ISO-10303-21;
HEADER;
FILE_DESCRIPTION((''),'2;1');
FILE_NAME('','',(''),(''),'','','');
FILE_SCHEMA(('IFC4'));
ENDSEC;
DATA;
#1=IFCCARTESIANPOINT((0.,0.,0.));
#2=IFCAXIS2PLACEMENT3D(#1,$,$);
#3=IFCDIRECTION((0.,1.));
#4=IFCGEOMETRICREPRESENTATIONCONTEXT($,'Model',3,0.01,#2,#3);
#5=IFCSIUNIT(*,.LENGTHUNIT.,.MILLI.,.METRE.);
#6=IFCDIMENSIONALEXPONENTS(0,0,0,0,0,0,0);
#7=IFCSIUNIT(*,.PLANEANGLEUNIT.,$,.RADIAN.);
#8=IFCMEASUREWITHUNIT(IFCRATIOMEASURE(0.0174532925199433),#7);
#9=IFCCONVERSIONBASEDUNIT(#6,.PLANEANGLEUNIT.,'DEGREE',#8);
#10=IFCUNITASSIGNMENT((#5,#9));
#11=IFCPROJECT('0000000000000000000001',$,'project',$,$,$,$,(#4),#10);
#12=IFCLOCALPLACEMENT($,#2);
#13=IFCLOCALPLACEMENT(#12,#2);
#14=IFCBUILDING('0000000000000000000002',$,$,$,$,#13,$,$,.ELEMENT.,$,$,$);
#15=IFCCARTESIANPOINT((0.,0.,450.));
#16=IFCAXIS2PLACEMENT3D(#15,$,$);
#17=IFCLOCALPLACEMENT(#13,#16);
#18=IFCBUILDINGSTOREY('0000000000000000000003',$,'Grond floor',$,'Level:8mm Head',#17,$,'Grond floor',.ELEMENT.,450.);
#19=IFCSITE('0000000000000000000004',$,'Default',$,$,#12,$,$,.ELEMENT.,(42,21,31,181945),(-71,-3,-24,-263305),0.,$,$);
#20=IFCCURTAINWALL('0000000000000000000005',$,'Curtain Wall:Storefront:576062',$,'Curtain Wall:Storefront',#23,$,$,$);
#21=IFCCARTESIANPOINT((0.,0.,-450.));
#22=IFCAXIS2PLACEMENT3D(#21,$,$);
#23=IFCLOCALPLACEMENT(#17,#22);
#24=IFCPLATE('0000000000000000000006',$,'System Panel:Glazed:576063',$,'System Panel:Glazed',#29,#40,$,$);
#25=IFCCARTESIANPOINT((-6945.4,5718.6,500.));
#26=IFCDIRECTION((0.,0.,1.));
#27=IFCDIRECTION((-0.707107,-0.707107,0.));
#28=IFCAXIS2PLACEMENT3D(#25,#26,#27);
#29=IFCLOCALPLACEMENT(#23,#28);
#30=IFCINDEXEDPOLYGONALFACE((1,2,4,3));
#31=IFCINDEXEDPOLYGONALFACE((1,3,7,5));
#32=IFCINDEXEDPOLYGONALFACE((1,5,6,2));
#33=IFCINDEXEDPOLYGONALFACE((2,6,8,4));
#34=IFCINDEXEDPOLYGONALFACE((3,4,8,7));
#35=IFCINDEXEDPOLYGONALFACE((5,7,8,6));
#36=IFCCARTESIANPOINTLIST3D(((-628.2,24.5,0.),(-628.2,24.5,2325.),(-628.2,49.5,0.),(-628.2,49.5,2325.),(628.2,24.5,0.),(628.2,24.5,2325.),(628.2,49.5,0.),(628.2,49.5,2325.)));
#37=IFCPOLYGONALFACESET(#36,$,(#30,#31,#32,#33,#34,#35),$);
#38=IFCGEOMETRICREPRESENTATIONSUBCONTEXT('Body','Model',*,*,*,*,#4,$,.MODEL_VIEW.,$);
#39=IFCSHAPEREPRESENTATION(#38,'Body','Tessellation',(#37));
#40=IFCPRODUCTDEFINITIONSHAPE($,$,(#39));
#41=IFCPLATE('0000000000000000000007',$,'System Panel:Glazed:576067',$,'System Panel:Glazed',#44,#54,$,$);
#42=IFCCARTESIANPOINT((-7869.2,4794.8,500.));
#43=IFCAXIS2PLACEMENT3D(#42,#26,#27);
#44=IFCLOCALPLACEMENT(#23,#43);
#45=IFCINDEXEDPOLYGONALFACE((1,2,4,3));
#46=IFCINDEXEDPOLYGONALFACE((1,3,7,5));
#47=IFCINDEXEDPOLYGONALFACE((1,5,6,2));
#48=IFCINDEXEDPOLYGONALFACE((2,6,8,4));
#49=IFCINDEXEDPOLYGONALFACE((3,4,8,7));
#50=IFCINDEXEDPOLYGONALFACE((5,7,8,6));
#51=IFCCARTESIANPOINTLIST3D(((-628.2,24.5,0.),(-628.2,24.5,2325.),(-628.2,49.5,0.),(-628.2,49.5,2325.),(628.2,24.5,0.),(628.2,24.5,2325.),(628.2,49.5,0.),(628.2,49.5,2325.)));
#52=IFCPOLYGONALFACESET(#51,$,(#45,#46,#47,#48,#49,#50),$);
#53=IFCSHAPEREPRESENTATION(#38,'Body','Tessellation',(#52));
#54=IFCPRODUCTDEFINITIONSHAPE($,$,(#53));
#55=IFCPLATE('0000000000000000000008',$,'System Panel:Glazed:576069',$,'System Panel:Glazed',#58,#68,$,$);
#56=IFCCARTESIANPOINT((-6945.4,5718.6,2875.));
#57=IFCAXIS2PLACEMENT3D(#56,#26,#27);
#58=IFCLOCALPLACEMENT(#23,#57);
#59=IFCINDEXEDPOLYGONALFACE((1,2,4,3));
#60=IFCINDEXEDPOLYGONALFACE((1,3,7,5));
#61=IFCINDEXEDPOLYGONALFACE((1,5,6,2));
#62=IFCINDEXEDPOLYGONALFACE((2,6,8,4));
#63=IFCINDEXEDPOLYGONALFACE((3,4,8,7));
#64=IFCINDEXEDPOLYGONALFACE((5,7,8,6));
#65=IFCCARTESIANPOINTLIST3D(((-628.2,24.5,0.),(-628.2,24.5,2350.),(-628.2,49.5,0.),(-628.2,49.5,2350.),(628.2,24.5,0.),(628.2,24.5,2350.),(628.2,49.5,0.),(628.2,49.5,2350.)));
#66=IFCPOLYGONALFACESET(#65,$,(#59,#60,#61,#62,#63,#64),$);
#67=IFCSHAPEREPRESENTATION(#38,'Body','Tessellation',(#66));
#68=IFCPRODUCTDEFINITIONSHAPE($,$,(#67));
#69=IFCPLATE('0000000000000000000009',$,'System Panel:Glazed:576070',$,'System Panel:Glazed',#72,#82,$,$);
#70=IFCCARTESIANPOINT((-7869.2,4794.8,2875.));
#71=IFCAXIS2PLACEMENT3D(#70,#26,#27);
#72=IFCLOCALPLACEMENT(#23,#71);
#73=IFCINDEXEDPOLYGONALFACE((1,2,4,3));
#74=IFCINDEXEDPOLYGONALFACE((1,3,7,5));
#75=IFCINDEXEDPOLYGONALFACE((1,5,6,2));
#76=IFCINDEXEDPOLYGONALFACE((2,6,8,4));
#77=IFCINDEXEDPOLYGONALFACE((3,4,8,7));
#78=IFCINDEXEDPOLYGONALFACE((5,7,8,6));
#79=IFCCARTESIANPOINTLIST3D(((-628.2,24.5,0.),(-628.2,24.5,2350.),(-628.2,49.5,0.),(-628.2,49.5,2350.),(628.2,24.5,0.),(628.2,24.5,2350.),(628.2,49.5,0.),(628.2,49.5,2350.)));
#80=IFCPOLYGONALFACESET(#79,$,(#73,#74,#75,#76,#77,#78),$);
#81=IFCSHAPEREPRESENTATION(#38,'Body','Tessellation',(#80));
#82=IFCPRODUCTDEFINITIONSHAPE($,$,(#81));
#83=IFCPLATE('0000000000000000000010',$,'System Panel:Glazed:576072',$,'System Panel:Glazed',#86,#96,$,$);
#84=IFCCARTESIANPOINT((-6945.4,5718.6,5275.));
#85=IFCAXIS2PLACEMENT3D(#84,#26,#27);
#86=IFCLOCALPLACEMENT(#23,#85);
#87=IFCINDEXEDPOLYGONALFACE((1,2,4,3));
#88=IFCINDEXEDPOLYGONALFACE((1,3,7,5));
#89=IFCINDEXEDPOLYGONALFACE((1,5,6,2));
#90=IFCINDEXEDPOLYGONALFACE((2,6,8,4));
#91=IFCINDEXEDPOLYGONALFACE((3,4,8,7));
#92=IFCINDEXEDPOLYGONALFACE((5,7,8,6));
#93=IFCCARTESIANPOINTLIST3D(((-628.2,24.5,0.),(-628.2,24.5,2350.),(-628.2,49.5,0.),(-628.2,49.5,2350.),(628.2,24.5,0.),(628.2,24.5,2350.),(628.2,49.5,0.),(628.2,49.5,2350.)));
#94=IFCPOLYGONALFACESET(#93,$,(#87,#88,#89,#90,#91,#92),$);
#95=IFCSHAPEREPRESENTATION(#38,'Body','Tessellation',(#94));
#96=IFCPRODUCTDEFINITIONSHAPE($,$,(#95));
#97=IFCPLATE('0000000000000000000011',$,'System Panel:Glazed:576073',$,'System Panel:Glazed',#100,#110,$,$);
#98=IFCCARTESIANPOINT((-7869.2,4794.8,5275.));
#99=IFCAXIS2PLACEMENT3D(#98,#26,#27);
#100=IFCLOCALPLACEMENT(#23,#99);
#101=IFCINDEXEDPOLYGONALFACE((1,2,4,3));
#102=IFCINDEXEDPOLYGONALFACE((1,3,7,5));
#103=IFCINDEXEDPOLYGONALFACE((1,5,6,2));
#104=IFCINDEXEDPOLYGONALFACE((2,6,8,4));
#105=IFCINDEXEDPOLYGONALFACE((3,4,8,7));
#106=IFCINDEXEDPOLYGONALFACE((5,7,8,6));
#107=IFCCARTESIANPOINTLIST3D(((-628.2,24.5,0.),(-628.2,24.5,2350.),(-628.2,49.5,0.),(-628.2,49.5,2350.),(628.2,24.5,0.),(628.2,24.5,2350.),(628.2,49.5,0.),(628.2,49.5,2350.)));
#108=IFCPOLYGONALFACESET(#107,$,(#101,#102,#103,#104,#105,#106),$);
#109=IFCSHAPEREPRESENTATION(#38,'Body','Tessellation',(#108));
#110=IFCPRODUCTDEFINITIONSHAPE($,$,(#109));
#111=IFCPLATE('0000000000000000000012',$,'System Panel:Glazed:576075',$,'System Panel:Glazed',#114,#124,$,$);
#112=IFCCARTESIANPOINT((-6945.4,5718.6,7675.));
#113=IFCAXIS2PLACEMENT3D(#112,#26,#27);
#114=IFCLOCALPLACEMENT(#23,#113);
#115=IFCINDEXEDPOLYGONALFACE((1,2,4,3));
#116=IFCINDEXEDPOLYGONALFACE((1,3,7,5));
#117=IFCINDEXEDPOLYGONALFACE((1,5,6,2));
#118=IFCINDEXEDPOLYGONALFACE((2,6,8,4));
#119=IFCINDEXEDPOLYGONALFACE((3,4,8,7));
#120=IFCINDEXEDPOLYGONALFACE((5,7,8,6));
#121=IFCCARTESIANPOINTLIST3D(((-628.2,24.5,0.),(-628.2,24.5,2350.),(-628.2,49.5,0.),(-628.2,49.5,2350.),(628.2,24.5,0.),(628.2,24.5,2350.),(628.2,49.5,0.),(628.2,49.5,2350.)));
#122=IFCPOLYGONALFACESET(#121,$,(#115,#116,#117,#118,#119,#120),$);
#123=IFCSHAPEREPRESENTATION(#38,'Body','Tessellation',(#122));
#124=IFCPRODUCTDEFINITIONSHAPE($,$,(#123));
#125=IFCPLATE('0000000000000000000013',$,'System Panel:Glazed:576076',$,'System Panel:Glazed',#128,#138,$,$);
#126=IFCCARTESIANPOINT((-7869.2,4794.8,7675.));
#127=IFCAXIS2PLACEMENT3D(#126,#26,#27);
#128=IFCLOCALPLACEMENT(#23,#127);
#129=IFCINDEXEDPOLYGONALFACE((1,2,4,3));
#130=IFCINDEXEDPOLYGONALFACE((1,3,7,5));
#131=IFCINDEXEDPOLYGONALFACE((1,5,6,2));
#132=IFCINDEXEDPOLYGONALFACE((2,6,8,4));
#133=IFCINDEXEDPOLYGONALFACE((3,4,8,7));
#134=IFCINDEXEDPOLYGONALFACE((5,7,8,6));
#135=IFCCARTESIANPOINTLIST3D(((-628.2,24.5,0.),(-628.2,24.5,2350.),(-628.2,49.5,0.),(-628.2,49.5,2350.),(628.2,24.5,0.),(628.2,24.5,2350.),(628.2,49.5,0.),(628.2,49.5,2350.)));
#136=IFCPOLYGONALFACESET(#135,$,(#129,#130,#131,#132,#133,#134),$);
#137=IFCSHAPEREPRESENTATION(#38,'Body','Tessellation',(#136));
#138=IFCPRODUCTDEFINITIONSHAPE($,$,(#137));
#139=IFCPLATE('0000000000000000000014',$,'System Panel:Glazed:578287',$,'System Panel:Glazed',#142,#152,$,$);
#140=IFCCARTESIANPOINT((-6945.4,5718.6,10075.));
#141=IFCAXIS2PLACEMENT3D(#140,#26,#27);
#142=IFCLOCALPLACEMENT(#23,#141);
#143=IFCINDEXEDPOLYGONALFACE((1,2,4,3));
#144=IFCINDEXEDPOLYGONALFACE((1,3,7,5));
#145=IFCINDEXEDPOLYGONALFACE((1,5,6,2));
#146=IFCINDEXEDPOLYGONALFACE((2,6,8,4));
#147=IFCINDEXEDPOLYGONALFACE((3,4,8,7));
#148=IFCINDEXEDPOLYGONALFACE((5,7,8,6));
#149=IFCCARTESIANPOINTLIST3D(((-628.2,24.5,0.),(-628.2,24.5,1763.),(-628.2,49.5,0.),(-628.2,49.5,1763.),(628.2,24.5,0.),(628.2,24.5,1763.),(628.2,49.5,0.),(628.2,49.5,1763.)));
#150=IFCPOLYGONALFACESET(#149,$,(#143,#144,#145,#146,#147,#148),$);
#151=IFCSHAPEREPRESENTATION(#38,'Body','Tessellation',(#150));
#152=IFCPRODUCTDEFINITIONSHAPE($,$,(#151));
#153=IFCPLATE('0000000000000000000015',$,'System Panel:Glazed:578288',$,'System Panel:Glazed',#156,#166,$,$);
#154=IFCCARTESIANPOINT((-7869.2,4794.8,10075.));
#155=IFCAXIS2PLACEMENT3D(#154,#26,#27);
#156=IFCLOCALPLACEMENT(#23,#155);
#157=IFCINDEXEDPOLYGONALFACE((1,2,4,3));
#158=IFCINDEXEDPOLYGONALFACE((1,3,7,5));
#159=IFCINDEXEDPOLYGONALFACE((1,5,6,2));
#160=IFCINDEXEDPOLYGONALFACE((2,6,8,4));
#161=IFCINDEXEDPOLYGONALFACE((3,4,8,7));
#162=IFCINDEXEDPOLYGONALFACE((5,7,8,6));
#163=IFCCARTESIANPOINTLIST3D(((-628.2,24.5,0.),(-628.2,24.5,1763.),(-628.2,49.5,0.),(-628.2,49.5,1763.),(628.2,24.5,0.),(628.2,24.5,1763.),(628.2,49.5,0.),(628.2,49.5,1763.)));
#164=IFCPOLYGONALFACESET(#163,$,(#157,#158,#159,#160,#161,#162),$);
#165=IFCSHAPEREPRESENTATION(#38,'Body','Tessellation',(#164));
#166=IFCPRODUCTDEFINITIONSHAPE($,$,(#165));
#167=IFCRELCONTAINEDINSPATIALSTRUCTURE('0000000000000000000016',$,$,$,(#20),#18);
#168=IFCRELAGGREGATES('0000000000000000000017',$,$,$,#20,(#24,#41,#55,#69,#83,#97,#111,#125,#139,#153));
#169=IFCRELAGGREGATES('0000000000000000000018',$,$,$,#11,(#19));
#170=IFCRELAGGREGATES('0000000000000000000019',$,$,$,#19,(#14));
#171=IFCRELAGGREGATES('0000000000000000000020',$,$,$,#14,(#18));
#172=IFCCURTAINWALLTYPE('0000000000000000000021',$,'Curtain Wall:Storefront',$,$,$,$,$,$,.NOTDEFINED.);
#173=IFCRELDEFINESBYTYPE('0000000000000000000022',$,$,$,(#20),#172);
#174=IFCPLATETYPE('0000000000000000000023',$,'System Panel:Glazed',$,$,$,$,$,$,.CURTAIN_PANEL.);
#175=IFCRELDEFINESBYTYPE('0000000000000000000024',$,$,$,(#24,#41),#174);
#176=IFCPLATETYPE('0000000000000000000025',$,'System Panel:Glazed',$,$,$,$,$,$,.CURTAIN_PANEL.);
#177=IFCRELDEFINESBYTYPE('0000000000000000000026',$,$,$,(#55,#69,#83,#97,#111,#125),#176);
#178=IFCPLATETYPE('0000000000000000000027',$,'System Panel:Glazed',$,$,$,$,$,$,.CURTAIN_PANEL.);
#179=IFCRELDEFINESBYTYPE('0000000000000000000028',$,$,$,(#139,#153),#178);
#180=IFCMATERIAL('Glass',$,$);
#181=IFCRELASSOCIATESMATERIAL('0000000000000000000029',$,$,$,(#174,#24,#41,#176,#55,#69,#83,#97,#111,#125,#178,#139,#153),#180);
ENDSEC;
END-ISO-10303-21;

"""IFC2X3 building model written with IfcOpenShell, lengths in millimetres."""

from ifc_helpers import new_model, entity, si_unit, converted_unit, direction, frame, origin, origin_2d_with_axis, place, context, subcontext, project, spatial, rectangle, extrude, source, transform, mapped, material, type_object, type_shapes, element, aggregate, save


model = new_model("IFC2X3")

# Units and contexts
model_context = context("Model", 3, precision=0.01, world=origin(), true_north=direction((0.0, 1.0)))
body_context = subcontext(model_context, "Body", "Model", "MODEL_VIEW")
ifc_project = project(units=[si_unit("LENGTHUNIT", "METRE", prefix="MILLI"), converted_unit("PLANEANGLEUNIT", "DEGREE", entity("IfcRatioMeasure", 0.0174532925199433), si_unit("PLANEANGLEUNIT", "RADIAN"), dimensions=[0, 0, 0, 0, 0, 0, 0])], contexts=[model_context])

# Site, building, storey
site_placement = place(None, origin())
site = spatial("IfcSite", under=ifc_project, at=site_placement, Name="Default", CompositionType="ELEMENT", RefLatitude=(42, 21, 31, 181945), RefLongitude=(-71, -3, -24, -263305), RefElevation=0.0)
building_placement = place(site_placement, origin())
building = spatial("IfcBuilding", under=site, at=building_placement, CompositionType="ELEMENT")
storey_placement = place(building_placement, frame((0.0, 0.0, 450.0)))
storey = spatial("IfcBuildingStorey", under=building, at=storey_placement, Name="Grond floor", ObjectType="Level:8mm Head", LongName="Grond floor", CompositionType="ELEMENT", Elevation=450.0)

# Curtain wall, plates
curtain_wall_type = type_object("IfcCurtainWallType", Name="Curtain Wall:Storefront", PredefinedType="NOTDEFINED")
curtain_wall_placement = place(storey_placement, frame((0.0, 0.0, -450.0)))
curtain_wall = element("IfcCurtainWall", 1, at=curtain_wall_placement, inside=storey, type_object=curtain_wall_type, Name="Curtain Wall:Storefront:576062", ObjectType="Curtain Wall:Storefront")
ifc_material_1 = material(Name="Glass")
plate_type_1 = type_object("IfcPlateType", Name="System Panel:Glazed", PredefinedType="CURTAIN_PANEL", material=ifc_material_1)
shared_shape_1 = source(origin(), body_context, "Body", "SweptSolid", [
    extrude(rectangle(XDim=25.0, YDim=1256.4, at=origin_2d_with_axis()), frame((0.0, 37.0, 0.0), z_axis=(0.0, 0.0, 1.0), x_axis=(0.0, 1.0, 0.0)), (0.0, 0.0, 1.0), 2325.0),
])
type_shapes(plate_type_1, [shared_shape_1])
plate_1_placement = place(curtain_wall_placement, frame((-6945.4, 5718.6, 500.0), z_axis=(0.0, 0.0, 1.0), x_axis=(-0.707107, -0.707107, 0.0)))
plate_1 = element("IfcPlate", 2, at=plate_1_placement, type_object=plate_type_1, material=ifc_material_1, Name="System Panel:Glazed:576063", ObjectType="System Panel:Glazed", context=body_context, shape_type="MappedRepresentation", body=[
    mapped(shared_shape_1, transform((0.0, 0.0, 0.0), scale=1.0)),
])
plate_2_placement = place(curtain_wall_placement, frame((-7869.2, 4794.8, 500.0), z_axis=(0.0, 0.0, 1.0), x_axis=(-0.707107, -0.707107, 0.0)))
plate_2 = element("IfcPlate", 3, at=plate_2_placement, type_object=plate_type_1, material=ifc_material_1, Name="System Panel:Glazed:576067", ObjectType="System Panel:Glazed", context=body_context, shape_type="MappedRepresentation", body=[
    mapped(shared_shape_1, transform((0.0, 0.0, 0.0), scale=1.0)),
])
plate_type_2 = type_object("IfcPlateType", Name="System Panel:Glazed", PredefinedType="CURTAIN_PANEL", material=ifc_material_1)
shared_shape_2 = source(origin(), body_context, "Body", "SweptSolid", [
    extrude(rectangle(XDim=25.0, YDim=1256.4, at=origin_2d_with_axis()), frame((0.0, 37.0, 0.0), z_axis=(0.0, 0.0, 1.0), x_axis=(0.0, 1.0, 0.0)), (0.0, 0.0, 1.0), 2350.0),
])
type_shapes(plate_type_2, [shared_shape_2])
plate_3_placement = place(curtain_wall_placement, frame((-6945.4, 5718.6, 2875.0), z_axis=(0.0, 0.0, 1.0), x_axis=(-0.707107, -0.707107, 0.0)))
plate_3 = element("IfcPlate", 4, at=plate_3_placement, type_object=plate_type_2, material=ifc_material_1, Name="System Panel:Glazed:576069", ObjectType="System Panel:Glazed", context=body_context, shape_type="MappedRepresentation", body=[
    mapped(shared_shape_2, transform((0.0, 0.0, 0.0), scale=1.0)),
])
plate_4_placement = place(curtain_wall_placement, frame((-7869.2, 4794.8, 2875.0), z_axis=(0.0, 0.0, 1.0), x_axis=(-0.707107, -0.707107, 0.0)))
plate_4 = element("IfcPlate", 5, at=plate_4_placement, type_object=plate_type_2, material=ifc_material_1, Name="System Panel:Glazed:576070", ObjectType="System Panel:Glazed", context=body_context, shape_type="MappedRepresentation", body=[
    mapped(shared_shape_2, transform((0.0, 0.0, 0.0), scale=1.0)),
])
plate_5_placement = place(curtain_wall_placement, frame((-6945.4, 5718.6, 5275.0), z_axis=(0.0, 0.0, 1.0), x_axis=(-0.707107, -0.707107, 0.0)))
plate_5 = element("IfcPlate", 6, at=plate_5_placement, type_object=plate_type_2, material=ifc_material_1, Name="System Panel:Glazed:576072", ObjectType="System Panel:Glazed", context=body_context, shape_type="MappedRepresentation", body=[
    mapped(shared_shape_2, transform((0.0, 0.0, 0.0), scale=1.0)),
])
plate_6_placement = place(curtain_wall_placement, frame((-7869.2, 4794.8, 5275.0), z_axis=(0.0, 0.0, 1.0), x_axis=(-0.707107, -0.707107, 0.0)))
plate_6 = element("IfcPlate", 7, at=plate_6_placement, type_object=plate_type_2, material=ifc_material_1, Name="System Panel:Glazed:576073", ObjectType="System Panel:Glazed", context=body_context, shape_type="MappedRepresentation", body=[
    mapped(shared_shape_2, transform((0.0, 0.0, 0.0), scale=1.0)),
])
plate_7_placement = place(curtain_wall_placement, frame((-6945.4, 5718.6, 7675.0), z_axis=(0.0, 0.0, 1.0), x_axis=(-0.707107, -0.707107, 0.0)))
plate_7 = element("IfcPlate", 8, at=plate_7_placement, type_object=plate_type_2, material=ifc_material_1, Name="System Panel:Glazed:576075", ObjectType="System Panel:Glazed", context=body_context, shape_type="MappedRepresentation", body=[
    mapped(shared_shape_2, transform((0.0, 0.0, 0.0), scale=1.0)),
])
plate_8_placement = place(curtain_wall_placement, frame((-7869.2, 4794.8, 7675.0), z_axis=(0.0, 0.0, 1.0), x_axis=(-0.707107, -0.707107, 0.0)))
plate_8 = element("IfcPlate", 9, at=plate_8_placement, type_object=plate_type_2, material=ifc_material_1, Name="System Panel:Glazed:576076", ObjectType="System Panel:Glazed", context=body_context, shape_type="MappedRepresentation", body=[
    mapped(shared_shape_2, transform((0.0, 0.0, 0.0), scale=1.0)),
])
plate_type_3 = type_object("IfcPlateType", Name="System Panel:Glazed", PredefinedType="CURTAIN_PANEL", material=ifc_material_1)
shared_shape_3 = source(origin(), body_context, "Body", "SweptSolid", [
    extrude(rectangle(XDim=25.0, YDim=1256.4, at=origin_2d_with_axis()), frame((0.0, 37.0, 0.0), z_axis=(0.0, 0.0, 1.0), x_axis=(0.0, 1.0, 0.0)), (0.0, 0.0, 1.0), 1763.0),
])
type_shapes(plate_type_3, [shared_shape_3])
plate_9_placement = place(curtain_wall_placement, frame((-6945.4, 5718.6, 10075.0), z_axis=(0.0, 0.0, 1.0), x_axis=(-0.707107, -0.707107, 0.0)))
plate_9 = element("IfcPlate", 10, at=plate_9_placement, type_object=plate_type_3, material=ifc_material_1, Name="System Panel:Glazed:578287", ObjectType="System Panel:Glazed", context=body_context, shape_type="MappedRepresentation", body=[
    mapped(shared_shape_3, transform((0.0, 0.0, 0.0), scale=1.0)),
])
plate_10_placement = place(curtain_wall_placement, frame((-7869.2, 4794.8, 10075.0), z_axis=(0.0, 0.0, 1.0), x_axis=(-0.707107, -0.707107, 0.0)))
plate_10 = element("IfcPlate", 11, at=plate_10_placement, type_object=plate_type_3, material=ifc_material_1, Name="System Panel:Glazed:578288", ObjectType="System Panel:Glazed", context=body_context, shape_type="MappedRepresentation", body=[
    mapped(shared_shape_3, transform((0.0, 0.0, 0.0), scale=1.0)),
])
aggregate(curtain_wall, [plate_1, plate_2, plate_3, plate_4, plate_5, plate_6, plate_7, plate_8, plate_9, plate_10])

save(model, "model.ifc")
